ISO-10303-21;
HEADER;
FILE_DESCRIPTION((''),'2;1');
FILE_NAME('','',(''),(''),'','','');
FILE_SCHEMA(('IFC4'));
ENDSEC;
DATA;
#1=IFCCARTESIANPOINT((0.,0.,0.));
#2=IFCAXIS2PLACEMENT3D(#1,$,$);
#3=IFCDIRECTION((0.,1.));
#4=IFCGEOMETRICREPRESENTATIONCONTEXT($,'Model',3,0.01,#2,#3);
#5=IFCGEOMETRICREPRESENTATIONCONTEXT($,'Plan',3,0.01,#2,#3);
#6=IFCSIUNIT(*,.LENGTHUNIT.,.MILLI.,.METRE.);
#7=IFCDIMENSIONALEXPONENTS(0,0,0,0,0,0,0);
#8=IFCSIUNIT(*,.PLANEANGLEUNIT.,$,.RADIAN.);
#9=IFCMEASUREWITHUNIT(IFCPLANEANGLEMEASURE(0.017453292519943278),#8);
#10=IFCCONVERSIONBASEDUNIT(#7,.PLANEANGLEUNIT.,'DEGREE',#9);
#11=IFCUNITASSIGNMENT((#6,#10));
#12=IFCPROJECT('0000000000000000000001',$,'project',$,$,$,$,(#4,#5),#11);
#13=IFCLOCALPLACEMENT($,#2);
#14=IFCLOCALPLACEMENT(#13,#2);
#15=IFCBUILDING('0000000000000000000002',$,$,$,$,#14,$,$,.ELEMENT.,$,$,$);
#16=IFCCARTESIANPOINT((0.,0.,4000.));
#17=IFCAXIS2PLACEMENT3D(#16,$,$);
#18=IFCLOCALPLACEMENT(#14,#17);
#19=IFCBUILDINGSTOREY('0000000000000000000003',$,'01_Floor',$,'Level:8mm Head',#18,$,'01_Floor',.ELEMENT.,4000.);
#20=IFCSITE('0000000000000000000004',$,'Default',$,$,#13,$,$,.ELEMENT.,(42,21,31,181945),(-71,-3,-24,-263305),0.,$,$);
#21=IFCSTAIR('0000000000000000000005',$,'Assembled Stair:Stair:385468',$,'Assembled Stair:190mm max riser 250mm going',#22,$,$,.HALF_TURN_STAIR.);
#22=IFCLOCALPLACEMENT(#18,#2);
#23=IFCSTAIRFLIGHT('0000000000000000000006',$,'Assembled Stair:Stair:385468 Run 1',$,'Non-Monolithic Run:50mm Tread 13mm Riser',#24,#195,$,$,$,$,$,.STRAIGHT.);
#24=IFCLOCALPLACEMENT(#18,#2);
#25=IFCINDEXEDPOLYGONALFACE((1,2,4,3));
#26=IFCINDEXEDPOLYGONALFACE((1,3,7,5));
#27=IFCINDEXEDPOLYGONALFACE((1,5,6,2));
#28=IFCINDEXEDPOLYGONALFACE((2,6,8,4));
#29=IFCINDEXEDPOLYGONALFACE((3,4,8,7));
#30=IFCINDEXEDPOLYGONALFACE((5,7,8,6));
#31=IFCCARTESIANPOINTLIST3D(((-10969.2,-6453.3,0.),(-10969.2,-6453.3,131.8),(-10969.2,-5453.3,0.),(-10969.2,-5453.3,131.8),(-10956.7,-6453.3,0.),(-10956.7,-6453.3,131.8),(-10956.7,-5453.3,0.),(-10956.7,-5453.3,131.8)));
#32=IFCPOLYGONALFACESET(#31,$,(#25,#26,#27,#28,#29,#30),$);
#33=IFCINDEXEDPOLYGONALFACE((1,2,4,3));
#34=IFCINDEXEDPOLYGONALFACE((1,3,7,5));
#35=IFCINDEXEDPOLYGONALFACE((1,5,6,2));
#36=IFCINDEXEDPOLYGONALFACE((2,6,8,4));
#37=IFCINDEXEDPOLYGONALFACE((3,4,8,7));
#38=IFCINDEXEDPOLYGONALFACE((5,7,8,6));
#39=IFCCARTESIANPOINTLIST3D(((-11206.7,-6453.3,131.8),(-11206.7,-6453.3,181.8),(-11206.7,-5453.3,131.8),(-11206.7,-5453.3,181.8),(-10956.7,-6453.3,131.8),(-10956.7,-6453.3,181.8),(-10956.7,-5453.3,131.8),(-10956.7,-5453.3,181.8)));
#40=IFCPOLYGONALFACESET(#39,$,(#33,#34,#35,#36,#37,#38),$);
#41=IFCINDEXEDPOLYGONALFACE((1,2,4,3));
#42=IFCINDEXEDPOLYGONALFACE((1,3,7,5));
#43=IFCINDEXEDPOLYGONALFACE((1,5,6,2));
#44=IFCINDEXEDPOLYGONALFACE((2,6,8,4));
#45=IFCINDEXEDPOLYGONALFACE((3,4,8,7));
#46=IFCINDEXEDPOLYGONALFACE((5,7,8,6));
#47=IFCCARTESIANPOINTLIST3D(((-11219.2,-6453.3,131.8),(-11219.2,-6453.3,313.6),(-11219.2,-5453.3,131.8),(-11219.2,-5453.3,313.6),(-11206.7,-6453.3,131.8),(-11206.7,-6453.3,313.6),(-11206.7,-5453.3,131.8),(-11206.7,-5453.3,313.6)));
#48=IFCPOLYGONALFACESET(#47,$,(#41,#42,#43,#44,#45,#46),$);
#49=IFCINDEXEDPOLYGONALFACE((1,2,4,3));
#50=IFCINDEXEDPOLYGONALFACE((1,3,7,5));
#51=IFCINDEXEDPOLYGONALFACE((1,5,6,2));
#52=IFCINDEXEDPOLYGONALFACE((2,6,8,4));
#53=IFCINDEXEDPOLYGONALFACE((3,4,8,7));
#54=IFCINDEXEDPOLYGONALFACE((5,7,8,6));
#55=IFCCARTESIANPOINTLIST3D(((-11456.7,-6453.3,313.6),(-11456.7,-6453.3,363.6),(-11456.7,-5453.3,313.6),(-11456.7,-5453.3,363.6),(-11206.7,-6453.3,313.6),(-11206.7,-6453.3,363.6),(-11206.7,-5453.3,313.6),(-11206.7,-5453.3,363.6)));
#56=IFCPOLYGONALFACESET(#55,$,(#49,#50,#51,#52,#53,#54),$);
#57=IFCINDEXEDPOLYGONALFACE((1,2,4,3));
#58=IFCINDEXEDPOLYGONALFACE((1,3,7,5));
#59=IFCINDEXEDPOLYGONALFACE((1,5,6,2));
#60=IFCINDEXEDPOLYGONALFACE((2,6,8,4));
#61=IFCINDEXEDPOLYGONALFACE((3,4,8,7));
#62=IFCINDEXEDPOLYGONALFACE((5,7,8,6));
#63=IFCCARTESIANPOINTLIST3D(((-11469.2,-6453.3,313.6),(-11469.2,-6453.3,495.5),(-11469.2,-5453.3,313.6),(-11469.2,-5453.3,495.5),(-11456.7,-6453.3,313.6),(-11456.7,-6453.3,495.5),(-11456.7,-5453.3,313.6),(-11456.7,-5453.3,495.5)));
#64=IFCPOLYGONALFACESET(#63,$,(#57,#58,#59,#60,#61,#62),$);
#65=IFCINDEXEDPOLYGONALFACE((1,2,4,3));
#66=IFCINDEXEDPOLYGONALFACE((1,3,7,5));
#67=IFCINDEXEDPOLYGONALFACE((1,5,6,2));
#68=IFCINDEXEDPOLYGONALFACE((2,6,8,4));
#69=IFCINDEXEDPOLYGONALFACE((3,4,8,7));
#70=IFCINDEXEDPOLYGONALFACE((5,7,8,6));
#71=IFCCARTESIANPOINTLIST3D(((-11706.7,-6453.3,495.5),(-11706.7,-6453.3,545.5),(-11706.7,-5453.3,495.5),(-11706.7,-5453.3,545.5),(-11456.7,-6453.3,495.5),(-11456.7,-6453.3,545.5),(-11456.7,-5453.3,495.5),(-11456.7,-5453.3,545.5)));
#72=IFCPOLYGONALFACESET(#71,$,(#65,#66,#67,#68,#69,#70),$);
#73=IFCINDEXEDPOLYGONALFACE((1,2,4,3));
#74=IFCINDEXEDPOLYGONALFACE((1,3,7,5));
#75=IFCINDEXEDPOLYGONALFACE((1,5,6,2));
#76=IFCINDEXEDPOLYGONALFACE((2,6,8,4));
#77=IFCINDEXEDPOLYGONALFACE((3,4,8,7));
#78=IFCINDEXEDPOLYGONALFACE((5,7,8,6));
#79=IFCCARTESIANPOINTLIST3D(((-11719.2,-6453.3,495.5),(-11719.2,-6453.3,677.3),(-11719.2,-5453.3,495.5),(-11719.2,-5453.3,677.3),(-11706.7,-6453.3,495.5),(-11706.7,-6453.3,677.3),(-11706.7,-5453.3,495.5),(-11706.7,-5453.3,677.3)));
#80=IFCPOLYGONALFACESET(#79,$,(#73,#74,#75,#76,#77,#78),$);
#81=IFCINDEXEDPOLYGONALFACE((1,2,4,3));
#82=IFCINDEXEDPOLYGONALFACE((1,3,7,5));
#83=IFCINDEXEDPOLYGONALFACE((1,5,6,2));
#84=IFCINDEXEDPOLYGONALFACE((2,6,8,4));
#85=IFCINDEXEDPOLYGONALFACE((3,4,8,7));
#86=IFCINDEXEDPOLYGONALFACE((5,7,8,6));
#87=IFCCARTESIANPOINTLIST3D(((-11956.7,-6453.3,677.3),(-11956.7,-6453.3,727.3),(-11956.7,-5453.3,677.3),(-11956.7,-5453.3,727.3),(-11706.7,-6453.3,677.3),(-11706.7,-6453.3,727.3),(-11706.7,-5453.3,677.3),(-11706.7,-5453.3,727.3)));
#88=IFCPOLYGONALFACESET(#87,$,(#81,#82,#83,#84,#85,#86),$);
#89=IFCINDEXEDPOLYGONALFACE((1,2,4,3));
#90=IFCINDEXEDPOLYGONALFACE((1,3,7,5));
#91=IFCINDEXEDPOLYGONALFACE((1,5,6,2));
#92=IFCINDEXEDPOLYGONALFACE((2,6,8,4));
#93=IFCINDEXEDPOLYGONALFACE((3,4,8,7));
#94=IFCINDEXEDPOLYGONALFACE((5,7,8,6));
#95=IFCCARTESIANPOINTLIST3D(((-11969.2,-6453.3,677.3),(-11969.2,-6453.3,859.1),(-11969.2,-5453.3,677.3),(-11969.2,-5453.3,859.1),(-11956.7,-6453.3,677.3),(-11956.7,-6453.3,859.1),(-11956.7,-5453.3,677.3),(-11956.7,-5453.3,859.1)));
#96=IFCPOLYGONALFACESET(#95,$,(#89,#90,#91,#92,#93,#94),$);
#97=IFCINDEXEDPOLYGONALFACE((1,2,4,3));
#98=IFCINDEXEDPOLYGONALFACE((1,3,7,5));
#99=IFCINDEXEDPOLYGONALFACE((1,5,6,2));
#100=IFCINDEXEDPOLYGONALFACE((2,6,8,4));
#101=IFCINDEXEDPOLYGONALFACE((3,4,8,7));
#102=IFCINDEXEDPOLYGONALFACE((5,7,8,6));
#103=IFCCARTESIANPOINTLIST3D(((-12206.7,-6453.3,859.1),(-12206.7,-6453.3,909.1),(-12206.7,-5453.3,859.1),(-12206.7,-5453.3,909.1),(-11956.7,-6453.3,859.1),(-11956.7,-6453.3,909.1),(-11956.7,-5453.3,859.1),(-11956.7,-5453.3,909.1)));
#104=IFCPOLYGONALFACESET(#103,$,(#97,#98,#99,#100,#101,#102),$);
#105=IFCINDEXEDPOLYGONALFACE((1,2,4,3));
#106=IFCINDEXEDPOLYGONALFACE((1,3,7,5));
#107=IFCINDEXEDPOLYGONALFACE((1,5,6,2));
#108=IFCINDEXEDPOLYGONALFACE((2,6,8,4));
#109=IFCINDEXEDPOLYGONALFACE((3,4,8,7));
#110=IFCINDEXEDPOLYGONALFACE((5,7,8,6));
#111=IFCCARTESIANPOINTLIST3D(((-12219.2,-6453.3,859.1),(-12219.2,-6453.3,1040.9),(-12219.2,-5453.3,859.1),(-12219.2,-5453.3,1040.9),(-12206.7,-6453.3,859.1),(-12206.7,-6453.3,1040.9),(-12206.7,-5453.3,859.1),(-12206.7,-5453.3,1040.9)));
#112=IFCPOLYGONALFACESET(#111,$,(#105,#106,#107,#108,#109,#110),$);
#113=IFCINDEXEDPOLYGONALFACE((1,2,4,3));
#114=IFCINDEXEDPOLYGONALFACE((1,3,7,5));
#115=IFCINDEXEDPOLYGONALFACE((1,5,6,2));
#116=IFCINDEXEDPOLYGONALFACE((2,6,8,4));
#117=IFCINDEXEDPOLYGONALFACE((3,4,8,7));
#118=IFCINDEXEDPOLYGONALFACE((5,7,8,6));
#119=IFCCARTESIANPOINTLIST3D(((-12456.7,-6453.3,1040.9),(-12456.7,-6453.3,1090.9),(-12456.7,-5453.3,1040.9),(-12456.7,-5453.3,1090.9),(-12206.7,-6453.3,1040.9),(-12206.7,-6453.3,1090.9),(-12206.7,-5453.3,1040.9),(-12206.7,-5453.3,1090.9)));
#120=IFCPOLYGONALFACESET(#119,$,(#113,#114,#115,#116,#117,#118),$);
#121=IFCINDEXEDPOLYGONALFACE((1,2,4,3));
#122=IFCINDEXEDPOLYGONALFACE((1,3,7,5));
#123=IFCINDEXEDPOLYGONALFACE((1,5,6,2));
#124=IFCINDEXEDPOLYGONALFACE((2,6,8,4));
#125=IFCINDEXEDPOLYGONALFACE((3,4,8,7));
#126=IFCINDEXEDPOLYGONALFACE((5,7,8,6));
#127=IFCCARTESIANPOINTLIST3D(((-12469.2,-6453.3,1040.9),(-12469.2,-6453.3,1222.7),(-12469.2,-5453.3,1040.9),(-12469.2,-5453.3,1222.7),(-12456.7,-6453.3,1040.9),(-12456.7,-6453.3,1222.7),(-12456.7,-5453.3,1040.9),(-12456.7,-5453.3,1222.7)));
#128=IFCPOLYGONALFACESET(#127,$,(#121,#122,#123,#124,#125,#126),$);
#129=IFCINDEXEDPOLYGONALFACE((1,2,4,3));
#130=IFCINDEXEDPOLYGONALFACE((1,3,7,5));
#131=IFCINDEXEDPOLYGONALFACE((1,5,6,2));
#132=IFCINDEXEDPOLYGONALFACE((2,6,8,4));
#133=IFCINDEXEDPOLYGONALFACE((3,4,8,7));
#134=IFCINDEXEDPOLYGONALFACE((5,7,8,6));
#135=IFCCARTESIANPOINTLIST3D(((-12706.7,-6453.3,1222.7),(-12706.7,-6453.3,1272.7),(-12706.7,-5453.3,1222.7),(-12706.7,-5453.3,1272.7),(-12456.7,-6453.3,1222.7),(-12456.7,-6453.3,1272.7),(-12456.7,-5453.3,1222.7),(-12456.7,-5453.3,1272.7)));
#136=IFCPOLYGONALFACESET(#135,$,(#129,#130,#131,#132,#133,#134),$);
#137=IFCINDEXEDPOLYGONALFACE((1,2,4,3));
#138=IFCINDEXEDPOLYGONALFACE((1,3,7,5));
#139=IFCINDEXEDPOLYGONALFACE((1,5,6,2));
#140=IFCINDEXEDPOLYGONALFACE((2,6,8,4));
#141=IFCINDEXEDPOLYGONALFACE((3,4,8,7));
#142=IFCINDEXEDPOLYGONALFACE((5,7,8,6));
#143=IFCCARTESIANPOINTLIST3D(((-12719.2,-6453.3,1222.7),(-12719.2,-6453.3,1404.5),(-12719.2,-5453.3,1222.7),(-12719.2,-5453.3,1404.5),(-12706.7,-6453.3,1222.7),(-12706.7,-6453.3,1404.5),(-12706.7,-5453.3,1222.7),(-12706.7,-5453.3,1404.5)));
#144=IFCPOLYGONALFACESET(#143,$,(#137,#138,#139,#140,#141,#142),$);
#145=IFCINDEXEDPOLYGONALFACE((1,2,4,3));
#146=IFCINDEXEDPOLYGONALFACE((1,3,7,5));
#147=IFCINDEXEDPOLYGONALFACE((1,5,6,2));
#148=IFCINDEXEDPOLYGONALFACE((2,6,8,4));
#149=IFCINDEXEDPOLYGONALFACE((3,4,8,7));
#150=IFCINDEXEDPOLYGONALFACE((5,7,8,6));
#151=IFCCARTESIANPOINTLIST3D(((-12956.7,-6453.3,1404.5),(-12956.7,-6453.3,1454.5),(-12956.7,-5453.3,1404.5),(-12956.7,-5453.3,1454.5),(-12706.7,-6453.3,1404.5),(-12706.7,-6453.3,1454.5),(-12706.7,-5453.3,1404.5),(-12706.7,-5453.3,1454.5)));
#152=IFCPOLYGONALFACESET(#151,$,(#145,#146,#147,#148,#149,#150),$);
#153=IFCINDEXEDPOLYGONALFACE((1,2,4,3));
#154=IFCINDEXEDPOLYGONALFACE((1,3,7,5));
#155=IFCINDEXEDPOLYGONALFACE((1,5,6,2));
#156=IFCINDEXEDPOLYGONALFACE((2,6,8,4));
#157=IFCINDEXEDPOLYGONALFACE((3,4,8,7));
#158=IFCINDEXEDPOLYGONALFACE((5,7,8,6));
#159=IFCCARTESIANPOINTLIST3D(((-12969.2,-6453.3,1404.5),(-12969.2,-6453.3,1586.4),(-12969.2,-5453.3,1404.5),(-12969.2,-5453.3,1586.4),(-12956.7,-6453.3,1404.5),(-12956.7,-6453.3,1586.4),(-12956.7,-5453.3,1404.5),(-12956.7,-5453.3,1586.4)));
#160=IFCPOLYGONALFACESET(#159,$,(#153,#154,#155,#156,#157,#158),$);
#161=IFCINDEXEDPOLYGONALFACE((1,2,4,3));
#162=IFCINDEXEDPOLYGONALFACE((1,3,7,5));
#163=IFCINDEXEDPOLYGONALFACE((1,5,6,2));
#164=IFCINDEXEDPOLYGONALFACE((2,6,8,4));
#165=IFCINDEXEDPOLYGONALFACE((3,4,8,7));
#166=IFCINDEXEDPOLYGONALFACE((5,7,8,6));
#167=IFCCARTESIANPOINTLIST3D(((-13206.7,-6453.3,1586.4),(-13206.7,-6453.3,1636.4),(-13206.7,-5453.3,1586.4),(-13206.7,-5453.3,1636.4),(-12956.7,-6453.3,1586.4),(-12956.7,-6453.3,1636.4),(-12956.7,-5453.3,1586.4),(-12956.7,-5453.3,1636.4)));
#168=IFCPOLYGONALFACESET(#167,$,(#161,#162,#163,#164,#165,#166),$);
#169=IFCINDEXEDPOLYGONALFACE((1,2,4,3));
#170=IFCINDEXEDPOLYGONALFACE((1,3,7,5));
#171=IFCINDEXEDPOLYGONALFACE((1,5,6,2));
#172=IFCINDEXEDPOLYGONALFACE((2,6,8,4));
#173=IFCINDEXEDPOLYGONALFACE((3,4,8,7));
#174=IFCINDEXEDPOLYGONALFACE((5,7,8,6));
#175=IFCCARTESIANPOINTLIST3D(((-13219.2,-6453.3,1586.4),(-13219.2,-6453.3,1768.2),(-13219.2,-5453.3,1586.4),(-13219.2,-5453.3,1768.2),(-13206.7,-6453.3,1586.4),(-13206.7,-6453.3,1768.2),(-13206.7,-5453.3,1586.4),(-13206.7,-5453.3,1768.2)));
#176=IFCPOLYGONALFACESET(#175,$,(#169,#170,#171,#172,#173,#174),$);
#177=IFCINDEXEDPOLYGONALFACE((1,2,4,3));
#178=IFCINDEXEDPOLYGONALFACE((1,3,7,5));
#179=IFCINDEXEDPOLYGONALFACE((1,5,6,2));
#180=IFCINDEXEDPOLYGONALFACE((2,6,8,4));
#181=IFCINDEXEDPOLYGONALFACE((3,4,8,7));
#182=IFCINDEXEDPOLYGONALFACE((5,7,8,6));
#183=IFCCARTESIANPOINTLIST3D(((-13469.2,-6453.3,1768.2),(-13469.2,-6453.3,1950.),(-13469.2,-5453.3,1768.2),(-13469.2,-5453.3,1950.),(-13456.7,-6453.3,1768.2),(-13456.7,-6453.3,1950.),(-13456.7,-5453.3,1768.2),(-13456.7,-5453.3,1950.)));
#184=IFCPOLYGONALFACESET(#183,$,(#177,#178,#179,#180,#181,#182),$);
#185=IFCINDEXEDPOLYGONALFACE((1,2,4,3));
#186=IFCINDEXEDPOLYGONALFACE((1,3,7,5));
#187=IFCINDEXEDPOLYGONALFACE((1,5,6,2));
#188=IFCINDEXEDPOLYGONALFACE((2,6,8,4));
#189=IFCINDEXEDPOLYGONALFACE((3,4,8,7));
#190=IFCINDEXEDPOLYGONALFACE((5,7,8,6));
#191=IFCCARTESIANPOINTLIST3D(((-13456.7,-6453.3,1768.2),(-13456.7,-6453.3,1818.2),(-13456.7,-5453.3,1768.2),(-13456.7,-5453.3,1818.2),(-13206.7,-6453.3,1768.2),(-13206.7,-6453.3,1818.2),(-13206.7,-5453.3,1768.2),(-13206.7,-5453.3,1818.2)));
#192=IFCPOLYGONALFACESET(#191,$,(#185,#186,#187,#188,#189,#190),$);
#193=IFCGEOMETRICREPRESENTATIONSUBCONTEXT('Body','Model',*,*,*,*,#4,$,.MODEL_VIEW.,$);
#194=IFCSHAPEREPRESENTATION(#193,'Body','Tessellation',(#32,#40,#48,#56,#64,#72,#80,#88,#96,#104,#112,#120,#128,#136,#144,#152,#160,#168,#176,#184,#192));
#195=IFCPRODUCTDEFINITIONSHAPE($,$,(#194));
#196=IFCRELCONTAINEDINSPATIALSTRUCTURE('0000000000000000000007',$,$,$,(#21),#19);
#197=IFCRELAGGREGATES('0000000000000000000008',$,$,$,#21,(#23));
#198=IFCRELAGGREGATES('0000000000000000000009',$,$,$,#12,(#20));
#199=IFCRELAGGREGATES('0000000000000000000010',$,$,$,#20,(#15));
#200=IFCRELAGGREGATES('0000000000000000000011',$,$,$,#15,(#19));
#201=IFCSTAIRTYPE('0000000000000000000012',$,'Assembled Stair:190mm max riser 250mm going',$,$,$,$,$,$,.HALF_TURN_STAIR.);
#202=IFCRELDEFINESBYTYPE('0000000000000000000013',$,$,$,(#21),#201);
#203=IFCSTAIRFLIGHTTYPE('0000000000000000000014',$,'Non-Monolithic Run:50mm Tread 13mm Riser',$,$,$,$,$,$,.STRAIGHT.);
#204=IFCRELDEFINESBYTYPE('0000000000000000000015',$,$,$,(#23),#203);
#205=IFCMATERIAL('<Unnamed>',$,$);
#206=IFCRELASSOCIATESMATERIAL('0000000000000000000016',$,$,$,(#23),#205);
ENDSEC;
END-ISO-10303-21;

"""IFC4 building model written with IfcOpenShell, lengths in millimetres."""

from ifc_helpers import new_model, entity, si_unit, converted_unit, direction, frame, origin, place, context, subcontext, project, spatial, indexed_curve, outline, extrude, material, type_object, element, aggregate, save


model = new_model("IFC4")

# Units and contexts
model_context = context("Model", 3, precision=0.01, world=origin(), true_north=direction((0.0, 1.0)))
plan_context = context("Plan", 3, precision=0.01, world=origin(), true_north=direction((0.0, 1.0)))
body_context = subcontext(model_context, "Body", "Model", "MODEL_VIEW")
ifc_project = project(units=[si_unit("LENGTHUNIT", "METRE", prefix="MILLI"), converted_unit("PLANEANGLEUNIT", "DEGREE", entity("IfcPlaneAngleMeasure", 0.017453292519943278), si_unit("PLANEANGLEUNIT", "RADIAN"), dimensions=[0, 0, 0, 0, 0, 0, 0])], contexts=[model_context, plan_context])

# Site, building, storey
site_placement = place(None, origin())
site = spatial("IfcSite", under=ifc_project, at=site_placement, Name="Default", CompositionType="ELEMENT", RefLatitude=(42, 21, 31, 181945), RefLongitude=(-71, -3, -24, -263305), RefElevation=0.0)
building_placement = place(site_placement, origin())
building = spatial("IfcBuilding", under=site, at=building_placement, CompositionType="ELEMENT")
storey_placement = place(building_placement, frame((0.0, 0.0, 4000.0)))
storey = spatial("IfcBuildingStorey", under=building, at=storey_placement, Name="01_Floor", ObjectType="Level:8mm Head", LongName="01_Floor", CompositionType="ELEMENT", Elevation=4000.0)

# Stair
stair_type = type_object("IfcStairType", Name="Assembled Stair:190mm max riser 250mm going", PredefinedType="HALF_TURN_STAIR")
stair_placement = place(storey_placement, origin())
stair = element("IfcStair", 1, at=stair_placement, inside=storey, type_object=stair_type, Name="Assembled Stair:Stair:385468", ObjectType="Assembled Stair:190mm max riser 250mm going", PredefinedType="HALF_TURN_STAIR")
ifc_material_1 = material(Name="<Unnamed>")

# Stair flight
stair_flight_type = type_object("IfcStairFlightType", Name="Non-Monolithic Run:50mm Tread 13mm Riser", PredefinedType="STRAIGHT")
stair_flight_1_placement = place(stair_placement, origin())
stair_flight_1 = element("IfcStairFlight", 2, at=stair_flight_1_placement, type_object=stair_flight_type, material=ifc_material_1, Name="Assembled Stair:Stair:385468 Run 1", ObjectType="Non-Monolithic Run:50mm Tread 13mm Riser", PredefinedType="STRAIGHT", context=body_context, shape_type="SweptSolid", body=[
    extrude(outline(indexed_curve([(-500.0, -6.3), (500.0, -6.3), (500.0, 6.2), (-500.0, 6.2), (-500.0, -6.3)], self_intersect=False)), frame((-10962.9, -5953.3, 0.0), z_axis=(0.0, 0.0, 1.0), x_axis=(0.0, -1.0, 0.0)), (0.0, 0.0, 1.0), 131.8),
    extrude(outline(indexed_curve([(-125.0, -500.0), (125.0, -500.0), (125.0, 500.0), (-125.0, 500.0), (-125.0, -500.0)], self_intersect=False)), frame((-11081.7, -5953.3, 131.8)), (0.0, 0.0, 1.0), 50.0),
    extrude(outline(indexed_curve([(-500.0, -6.2), (500.0, -6.2), (500.0, 6.3), (-500.0, 6.3), (-500.0, -6.2)], self_intersect=False)), frame((-11212.9, -5953.3, 131.8), z_axis=(0.0, 0.0, 1.0), x_axis=(0.0, -1.0, 0.0)), (0.0, 0.0, 1.0), 181.8),
    extrude(outline(indexed_curve([(-125.0, -500.0), (125.0, -500.0), (125.0, 500.0), (-125.0, 500.0), (-125.0, -500.0)], self_intersect=False)), frame((-11331.7, -5953.3, 313.6)), (0.0, 0.0, 1.0), 50.0),
    extrude(outline(indexed_curve([(-500.0, -6.3), (500.0, -6.3), (500.0, 6.2), (-500.0, 6.2), (-500.0, -6.3)], self_intersect=False)), frame((-11462.9, -5953.3, 313.6), z_axis=(0.0, 0.0, 1.0), x_axis=(0.0, -1.0, 0.0)), (0.0, 0.0, 1.0), 181.8),
    extrude(outline(indexed_curve([(-125.0, -500.0), (125.0, -500.0), (125.0, 500.0), (-125.0, 500.0), (-125.0, -500.0)], self_intersect=False)), frame((-11581.7, -5953.3, 495.5)), (0.0, 0.0, 1.0), 50.0),
    extrude(outline(indexed_curve([(-500.0, -6.2), (500.0, -6.2), (500.0, 6.3), (-500.0, 6.3), (-500.0, -6.2)], self_intersect=False)), frame((-11712.9, -5953.3, 495.5), z_axis=(0.0, 0.0, 1.0), x_axis=(0.0, -1.0, 0.0)), (0.0, 0.0, 1.0), 181.8),
    extrude(outline(indexed_curve([(-125.0, -500.0), (125.0, -500.0), (125.0, 500.0), (-125.0, 500.0), (-125.0, -500.0)], self_intersect=False)), frame((-11831.7, -5953.3, 677.3)), (0.0, 0.0, 1.0), 50.0),
    extrude(outline(indexed_curve([(-500.0, -6.2), (500.0, -6.2), (500.0, 6.3), (-500.0, 6.3), (-500.0, -6.2)], self_intersect=False)), frame((-11962.9, -5953.3, 677.3), z_axis=(0.0, 0.0, 1.0), x_axis=(0.0, -1.0, 0.0)), (0.0, 0.0, 1.0), 181.8),
    extrude(outline(indexed_curve([(-125.0, -500.0), (125.0, -500.0), (125.0, 500.0), (-125.0, 500.0), (-125.0, -500.0)], self_intersect=False)), frame((-12081.7, -5953.3, 859.1)), (0.0, 0.0, 1.0), 50.0),
    extrude(outline(indexed_curve([(-500.0, -6.2), (500.0, -6.2), (500.0, 6.3), (-500.0, 6.3), (-500.0, -6.2)], self_intersect=False)), frame((-12212.9, -5953.3, 859.1), z_axis=(0.0, 0.0, 1.0), x_axis=(0.0, -1.0, 0.0)), (0.0, 0.0, 1.0), 181.8),
    extrude(outline(indexed_curve([(-125.0, -500.0), (125.0, -500.0), (125.0, 500.0), (-125.0, 500.0), (-125.0, -500.0)], self_intersect=False)), frame((-12331.7, -5953.3, 1040.9)), (0.0, 0.0, 1.0), 50.0),
    extrude(outline(indexed_curve([(-500.0, -6.2), (500.0, -6.2), (500.0, 6.3), (-500.0, 6.3), (-500.0, -6.2)], self_intersect=False)), frame((-12462.9, -5953.3, 1040.9), z_axis=(0.0, 0.0, 1.0), x_axis=(0.0, -1.0, 0.0)), (0.0, 0.0, 1.0), 181.8),
    extrude(outline(indexed_curve([(-125.0, -500.0), (125.0, -500.0), (125.0, 500.0), (-125.0, 500.0), (-125.0, -500.0)], self_intersect=False)), frame((-12581.7, -5953.3, 1222.7)), (0.0, 0.0, 1.0), 50.0),
    extrude(outline(indexed_curve([(-500.0, -6.3), (500.0, -6.3), (500.0, 6.2), (-500.0, 6.2), (-500.0, -6.3)], self_intersect=False)), frame((-12712.9, -5953.3, 1222.7), z_axis=(0.0, 0.0, 1.0), x_axis=(0.0, -1.0, 0.0)), (0.0, 0.0, 1.0), 181.8),
    extrude(outline(indexed_curve([(-125.0, -500.0), (125.0, -500.0), (125.0, 500.0), (-125.0, 500.0), (-125.0, -500.0)], self_intersect=False)), frame((-12831.7, -5953.3, 1404.5)), (0.0, 0.0, 1.0), 50.0),
    extrude(outline(indexed_curve([(-500.0, -6.2), (500.0, -6.2), (500.0, 6.3), (-500.0, 6.3), (-500.0, -6.2)], self_intersect=False)), frame((-12962.9, -5953.3, 1404.5), z_axis=(0.0, 0.0, 1.0), x_axis=(0.0, -1.0, 0.0)), (0.0, 0.0, 1.0), 181.8),
    extrude(outline(indexed_curve([(-125.0, -500.0), (125.0, -500.0), (125.0, 500.0), (-125.0, 500.0), (-125.0, -500.0)], self_intersect=False)), frame((-13081.7, -5953.3, 1586.4)), (0.0, 0.0, 1.0), 50.0),
    extrude(outline(indexed_curve([(-500.0, -6.3), (500.0, -6.3), (500.0, 6.2), (-500.0, 6.2), (-500.0, -6.3)], self_intersect=False)), frame((-13212.9, -5953.3, 1586.4), z_axis=(0.0, 0.0, 1.0), x_axis=(0.0, -1.0, 0.0)), (0.0, 0.0, 1.0), 181.8),
    extrude(outline(indexed_curve([(-500.0, -6.3), (500.0, -6.3), (500.0, 6.2), (-500.0, 6.2), (-500.0, -6.3)], self_intersect=False)), frame((-13462.9, -5953.3, 1768.2), z_axis=(0.0, 0.0, 1.0), x_axis=(0.0, -1.0, 0.0)), (0.0, 0.0, 1.0), 181.8),
    extrude(outline(indexed_curve([(-125.0, -500.0), (125.0, -500.0), (125.0, 500.0), (-125.0, 500.0), (-125.0, -500.0)], self_intersect=False)), frame((-13331.7, -5953.3, 1768.2)), (0.0, 0.0, 1.0), 50.0),
])
aggregate(stair, [stair_flight_1])

save(model, "model.ifc")
